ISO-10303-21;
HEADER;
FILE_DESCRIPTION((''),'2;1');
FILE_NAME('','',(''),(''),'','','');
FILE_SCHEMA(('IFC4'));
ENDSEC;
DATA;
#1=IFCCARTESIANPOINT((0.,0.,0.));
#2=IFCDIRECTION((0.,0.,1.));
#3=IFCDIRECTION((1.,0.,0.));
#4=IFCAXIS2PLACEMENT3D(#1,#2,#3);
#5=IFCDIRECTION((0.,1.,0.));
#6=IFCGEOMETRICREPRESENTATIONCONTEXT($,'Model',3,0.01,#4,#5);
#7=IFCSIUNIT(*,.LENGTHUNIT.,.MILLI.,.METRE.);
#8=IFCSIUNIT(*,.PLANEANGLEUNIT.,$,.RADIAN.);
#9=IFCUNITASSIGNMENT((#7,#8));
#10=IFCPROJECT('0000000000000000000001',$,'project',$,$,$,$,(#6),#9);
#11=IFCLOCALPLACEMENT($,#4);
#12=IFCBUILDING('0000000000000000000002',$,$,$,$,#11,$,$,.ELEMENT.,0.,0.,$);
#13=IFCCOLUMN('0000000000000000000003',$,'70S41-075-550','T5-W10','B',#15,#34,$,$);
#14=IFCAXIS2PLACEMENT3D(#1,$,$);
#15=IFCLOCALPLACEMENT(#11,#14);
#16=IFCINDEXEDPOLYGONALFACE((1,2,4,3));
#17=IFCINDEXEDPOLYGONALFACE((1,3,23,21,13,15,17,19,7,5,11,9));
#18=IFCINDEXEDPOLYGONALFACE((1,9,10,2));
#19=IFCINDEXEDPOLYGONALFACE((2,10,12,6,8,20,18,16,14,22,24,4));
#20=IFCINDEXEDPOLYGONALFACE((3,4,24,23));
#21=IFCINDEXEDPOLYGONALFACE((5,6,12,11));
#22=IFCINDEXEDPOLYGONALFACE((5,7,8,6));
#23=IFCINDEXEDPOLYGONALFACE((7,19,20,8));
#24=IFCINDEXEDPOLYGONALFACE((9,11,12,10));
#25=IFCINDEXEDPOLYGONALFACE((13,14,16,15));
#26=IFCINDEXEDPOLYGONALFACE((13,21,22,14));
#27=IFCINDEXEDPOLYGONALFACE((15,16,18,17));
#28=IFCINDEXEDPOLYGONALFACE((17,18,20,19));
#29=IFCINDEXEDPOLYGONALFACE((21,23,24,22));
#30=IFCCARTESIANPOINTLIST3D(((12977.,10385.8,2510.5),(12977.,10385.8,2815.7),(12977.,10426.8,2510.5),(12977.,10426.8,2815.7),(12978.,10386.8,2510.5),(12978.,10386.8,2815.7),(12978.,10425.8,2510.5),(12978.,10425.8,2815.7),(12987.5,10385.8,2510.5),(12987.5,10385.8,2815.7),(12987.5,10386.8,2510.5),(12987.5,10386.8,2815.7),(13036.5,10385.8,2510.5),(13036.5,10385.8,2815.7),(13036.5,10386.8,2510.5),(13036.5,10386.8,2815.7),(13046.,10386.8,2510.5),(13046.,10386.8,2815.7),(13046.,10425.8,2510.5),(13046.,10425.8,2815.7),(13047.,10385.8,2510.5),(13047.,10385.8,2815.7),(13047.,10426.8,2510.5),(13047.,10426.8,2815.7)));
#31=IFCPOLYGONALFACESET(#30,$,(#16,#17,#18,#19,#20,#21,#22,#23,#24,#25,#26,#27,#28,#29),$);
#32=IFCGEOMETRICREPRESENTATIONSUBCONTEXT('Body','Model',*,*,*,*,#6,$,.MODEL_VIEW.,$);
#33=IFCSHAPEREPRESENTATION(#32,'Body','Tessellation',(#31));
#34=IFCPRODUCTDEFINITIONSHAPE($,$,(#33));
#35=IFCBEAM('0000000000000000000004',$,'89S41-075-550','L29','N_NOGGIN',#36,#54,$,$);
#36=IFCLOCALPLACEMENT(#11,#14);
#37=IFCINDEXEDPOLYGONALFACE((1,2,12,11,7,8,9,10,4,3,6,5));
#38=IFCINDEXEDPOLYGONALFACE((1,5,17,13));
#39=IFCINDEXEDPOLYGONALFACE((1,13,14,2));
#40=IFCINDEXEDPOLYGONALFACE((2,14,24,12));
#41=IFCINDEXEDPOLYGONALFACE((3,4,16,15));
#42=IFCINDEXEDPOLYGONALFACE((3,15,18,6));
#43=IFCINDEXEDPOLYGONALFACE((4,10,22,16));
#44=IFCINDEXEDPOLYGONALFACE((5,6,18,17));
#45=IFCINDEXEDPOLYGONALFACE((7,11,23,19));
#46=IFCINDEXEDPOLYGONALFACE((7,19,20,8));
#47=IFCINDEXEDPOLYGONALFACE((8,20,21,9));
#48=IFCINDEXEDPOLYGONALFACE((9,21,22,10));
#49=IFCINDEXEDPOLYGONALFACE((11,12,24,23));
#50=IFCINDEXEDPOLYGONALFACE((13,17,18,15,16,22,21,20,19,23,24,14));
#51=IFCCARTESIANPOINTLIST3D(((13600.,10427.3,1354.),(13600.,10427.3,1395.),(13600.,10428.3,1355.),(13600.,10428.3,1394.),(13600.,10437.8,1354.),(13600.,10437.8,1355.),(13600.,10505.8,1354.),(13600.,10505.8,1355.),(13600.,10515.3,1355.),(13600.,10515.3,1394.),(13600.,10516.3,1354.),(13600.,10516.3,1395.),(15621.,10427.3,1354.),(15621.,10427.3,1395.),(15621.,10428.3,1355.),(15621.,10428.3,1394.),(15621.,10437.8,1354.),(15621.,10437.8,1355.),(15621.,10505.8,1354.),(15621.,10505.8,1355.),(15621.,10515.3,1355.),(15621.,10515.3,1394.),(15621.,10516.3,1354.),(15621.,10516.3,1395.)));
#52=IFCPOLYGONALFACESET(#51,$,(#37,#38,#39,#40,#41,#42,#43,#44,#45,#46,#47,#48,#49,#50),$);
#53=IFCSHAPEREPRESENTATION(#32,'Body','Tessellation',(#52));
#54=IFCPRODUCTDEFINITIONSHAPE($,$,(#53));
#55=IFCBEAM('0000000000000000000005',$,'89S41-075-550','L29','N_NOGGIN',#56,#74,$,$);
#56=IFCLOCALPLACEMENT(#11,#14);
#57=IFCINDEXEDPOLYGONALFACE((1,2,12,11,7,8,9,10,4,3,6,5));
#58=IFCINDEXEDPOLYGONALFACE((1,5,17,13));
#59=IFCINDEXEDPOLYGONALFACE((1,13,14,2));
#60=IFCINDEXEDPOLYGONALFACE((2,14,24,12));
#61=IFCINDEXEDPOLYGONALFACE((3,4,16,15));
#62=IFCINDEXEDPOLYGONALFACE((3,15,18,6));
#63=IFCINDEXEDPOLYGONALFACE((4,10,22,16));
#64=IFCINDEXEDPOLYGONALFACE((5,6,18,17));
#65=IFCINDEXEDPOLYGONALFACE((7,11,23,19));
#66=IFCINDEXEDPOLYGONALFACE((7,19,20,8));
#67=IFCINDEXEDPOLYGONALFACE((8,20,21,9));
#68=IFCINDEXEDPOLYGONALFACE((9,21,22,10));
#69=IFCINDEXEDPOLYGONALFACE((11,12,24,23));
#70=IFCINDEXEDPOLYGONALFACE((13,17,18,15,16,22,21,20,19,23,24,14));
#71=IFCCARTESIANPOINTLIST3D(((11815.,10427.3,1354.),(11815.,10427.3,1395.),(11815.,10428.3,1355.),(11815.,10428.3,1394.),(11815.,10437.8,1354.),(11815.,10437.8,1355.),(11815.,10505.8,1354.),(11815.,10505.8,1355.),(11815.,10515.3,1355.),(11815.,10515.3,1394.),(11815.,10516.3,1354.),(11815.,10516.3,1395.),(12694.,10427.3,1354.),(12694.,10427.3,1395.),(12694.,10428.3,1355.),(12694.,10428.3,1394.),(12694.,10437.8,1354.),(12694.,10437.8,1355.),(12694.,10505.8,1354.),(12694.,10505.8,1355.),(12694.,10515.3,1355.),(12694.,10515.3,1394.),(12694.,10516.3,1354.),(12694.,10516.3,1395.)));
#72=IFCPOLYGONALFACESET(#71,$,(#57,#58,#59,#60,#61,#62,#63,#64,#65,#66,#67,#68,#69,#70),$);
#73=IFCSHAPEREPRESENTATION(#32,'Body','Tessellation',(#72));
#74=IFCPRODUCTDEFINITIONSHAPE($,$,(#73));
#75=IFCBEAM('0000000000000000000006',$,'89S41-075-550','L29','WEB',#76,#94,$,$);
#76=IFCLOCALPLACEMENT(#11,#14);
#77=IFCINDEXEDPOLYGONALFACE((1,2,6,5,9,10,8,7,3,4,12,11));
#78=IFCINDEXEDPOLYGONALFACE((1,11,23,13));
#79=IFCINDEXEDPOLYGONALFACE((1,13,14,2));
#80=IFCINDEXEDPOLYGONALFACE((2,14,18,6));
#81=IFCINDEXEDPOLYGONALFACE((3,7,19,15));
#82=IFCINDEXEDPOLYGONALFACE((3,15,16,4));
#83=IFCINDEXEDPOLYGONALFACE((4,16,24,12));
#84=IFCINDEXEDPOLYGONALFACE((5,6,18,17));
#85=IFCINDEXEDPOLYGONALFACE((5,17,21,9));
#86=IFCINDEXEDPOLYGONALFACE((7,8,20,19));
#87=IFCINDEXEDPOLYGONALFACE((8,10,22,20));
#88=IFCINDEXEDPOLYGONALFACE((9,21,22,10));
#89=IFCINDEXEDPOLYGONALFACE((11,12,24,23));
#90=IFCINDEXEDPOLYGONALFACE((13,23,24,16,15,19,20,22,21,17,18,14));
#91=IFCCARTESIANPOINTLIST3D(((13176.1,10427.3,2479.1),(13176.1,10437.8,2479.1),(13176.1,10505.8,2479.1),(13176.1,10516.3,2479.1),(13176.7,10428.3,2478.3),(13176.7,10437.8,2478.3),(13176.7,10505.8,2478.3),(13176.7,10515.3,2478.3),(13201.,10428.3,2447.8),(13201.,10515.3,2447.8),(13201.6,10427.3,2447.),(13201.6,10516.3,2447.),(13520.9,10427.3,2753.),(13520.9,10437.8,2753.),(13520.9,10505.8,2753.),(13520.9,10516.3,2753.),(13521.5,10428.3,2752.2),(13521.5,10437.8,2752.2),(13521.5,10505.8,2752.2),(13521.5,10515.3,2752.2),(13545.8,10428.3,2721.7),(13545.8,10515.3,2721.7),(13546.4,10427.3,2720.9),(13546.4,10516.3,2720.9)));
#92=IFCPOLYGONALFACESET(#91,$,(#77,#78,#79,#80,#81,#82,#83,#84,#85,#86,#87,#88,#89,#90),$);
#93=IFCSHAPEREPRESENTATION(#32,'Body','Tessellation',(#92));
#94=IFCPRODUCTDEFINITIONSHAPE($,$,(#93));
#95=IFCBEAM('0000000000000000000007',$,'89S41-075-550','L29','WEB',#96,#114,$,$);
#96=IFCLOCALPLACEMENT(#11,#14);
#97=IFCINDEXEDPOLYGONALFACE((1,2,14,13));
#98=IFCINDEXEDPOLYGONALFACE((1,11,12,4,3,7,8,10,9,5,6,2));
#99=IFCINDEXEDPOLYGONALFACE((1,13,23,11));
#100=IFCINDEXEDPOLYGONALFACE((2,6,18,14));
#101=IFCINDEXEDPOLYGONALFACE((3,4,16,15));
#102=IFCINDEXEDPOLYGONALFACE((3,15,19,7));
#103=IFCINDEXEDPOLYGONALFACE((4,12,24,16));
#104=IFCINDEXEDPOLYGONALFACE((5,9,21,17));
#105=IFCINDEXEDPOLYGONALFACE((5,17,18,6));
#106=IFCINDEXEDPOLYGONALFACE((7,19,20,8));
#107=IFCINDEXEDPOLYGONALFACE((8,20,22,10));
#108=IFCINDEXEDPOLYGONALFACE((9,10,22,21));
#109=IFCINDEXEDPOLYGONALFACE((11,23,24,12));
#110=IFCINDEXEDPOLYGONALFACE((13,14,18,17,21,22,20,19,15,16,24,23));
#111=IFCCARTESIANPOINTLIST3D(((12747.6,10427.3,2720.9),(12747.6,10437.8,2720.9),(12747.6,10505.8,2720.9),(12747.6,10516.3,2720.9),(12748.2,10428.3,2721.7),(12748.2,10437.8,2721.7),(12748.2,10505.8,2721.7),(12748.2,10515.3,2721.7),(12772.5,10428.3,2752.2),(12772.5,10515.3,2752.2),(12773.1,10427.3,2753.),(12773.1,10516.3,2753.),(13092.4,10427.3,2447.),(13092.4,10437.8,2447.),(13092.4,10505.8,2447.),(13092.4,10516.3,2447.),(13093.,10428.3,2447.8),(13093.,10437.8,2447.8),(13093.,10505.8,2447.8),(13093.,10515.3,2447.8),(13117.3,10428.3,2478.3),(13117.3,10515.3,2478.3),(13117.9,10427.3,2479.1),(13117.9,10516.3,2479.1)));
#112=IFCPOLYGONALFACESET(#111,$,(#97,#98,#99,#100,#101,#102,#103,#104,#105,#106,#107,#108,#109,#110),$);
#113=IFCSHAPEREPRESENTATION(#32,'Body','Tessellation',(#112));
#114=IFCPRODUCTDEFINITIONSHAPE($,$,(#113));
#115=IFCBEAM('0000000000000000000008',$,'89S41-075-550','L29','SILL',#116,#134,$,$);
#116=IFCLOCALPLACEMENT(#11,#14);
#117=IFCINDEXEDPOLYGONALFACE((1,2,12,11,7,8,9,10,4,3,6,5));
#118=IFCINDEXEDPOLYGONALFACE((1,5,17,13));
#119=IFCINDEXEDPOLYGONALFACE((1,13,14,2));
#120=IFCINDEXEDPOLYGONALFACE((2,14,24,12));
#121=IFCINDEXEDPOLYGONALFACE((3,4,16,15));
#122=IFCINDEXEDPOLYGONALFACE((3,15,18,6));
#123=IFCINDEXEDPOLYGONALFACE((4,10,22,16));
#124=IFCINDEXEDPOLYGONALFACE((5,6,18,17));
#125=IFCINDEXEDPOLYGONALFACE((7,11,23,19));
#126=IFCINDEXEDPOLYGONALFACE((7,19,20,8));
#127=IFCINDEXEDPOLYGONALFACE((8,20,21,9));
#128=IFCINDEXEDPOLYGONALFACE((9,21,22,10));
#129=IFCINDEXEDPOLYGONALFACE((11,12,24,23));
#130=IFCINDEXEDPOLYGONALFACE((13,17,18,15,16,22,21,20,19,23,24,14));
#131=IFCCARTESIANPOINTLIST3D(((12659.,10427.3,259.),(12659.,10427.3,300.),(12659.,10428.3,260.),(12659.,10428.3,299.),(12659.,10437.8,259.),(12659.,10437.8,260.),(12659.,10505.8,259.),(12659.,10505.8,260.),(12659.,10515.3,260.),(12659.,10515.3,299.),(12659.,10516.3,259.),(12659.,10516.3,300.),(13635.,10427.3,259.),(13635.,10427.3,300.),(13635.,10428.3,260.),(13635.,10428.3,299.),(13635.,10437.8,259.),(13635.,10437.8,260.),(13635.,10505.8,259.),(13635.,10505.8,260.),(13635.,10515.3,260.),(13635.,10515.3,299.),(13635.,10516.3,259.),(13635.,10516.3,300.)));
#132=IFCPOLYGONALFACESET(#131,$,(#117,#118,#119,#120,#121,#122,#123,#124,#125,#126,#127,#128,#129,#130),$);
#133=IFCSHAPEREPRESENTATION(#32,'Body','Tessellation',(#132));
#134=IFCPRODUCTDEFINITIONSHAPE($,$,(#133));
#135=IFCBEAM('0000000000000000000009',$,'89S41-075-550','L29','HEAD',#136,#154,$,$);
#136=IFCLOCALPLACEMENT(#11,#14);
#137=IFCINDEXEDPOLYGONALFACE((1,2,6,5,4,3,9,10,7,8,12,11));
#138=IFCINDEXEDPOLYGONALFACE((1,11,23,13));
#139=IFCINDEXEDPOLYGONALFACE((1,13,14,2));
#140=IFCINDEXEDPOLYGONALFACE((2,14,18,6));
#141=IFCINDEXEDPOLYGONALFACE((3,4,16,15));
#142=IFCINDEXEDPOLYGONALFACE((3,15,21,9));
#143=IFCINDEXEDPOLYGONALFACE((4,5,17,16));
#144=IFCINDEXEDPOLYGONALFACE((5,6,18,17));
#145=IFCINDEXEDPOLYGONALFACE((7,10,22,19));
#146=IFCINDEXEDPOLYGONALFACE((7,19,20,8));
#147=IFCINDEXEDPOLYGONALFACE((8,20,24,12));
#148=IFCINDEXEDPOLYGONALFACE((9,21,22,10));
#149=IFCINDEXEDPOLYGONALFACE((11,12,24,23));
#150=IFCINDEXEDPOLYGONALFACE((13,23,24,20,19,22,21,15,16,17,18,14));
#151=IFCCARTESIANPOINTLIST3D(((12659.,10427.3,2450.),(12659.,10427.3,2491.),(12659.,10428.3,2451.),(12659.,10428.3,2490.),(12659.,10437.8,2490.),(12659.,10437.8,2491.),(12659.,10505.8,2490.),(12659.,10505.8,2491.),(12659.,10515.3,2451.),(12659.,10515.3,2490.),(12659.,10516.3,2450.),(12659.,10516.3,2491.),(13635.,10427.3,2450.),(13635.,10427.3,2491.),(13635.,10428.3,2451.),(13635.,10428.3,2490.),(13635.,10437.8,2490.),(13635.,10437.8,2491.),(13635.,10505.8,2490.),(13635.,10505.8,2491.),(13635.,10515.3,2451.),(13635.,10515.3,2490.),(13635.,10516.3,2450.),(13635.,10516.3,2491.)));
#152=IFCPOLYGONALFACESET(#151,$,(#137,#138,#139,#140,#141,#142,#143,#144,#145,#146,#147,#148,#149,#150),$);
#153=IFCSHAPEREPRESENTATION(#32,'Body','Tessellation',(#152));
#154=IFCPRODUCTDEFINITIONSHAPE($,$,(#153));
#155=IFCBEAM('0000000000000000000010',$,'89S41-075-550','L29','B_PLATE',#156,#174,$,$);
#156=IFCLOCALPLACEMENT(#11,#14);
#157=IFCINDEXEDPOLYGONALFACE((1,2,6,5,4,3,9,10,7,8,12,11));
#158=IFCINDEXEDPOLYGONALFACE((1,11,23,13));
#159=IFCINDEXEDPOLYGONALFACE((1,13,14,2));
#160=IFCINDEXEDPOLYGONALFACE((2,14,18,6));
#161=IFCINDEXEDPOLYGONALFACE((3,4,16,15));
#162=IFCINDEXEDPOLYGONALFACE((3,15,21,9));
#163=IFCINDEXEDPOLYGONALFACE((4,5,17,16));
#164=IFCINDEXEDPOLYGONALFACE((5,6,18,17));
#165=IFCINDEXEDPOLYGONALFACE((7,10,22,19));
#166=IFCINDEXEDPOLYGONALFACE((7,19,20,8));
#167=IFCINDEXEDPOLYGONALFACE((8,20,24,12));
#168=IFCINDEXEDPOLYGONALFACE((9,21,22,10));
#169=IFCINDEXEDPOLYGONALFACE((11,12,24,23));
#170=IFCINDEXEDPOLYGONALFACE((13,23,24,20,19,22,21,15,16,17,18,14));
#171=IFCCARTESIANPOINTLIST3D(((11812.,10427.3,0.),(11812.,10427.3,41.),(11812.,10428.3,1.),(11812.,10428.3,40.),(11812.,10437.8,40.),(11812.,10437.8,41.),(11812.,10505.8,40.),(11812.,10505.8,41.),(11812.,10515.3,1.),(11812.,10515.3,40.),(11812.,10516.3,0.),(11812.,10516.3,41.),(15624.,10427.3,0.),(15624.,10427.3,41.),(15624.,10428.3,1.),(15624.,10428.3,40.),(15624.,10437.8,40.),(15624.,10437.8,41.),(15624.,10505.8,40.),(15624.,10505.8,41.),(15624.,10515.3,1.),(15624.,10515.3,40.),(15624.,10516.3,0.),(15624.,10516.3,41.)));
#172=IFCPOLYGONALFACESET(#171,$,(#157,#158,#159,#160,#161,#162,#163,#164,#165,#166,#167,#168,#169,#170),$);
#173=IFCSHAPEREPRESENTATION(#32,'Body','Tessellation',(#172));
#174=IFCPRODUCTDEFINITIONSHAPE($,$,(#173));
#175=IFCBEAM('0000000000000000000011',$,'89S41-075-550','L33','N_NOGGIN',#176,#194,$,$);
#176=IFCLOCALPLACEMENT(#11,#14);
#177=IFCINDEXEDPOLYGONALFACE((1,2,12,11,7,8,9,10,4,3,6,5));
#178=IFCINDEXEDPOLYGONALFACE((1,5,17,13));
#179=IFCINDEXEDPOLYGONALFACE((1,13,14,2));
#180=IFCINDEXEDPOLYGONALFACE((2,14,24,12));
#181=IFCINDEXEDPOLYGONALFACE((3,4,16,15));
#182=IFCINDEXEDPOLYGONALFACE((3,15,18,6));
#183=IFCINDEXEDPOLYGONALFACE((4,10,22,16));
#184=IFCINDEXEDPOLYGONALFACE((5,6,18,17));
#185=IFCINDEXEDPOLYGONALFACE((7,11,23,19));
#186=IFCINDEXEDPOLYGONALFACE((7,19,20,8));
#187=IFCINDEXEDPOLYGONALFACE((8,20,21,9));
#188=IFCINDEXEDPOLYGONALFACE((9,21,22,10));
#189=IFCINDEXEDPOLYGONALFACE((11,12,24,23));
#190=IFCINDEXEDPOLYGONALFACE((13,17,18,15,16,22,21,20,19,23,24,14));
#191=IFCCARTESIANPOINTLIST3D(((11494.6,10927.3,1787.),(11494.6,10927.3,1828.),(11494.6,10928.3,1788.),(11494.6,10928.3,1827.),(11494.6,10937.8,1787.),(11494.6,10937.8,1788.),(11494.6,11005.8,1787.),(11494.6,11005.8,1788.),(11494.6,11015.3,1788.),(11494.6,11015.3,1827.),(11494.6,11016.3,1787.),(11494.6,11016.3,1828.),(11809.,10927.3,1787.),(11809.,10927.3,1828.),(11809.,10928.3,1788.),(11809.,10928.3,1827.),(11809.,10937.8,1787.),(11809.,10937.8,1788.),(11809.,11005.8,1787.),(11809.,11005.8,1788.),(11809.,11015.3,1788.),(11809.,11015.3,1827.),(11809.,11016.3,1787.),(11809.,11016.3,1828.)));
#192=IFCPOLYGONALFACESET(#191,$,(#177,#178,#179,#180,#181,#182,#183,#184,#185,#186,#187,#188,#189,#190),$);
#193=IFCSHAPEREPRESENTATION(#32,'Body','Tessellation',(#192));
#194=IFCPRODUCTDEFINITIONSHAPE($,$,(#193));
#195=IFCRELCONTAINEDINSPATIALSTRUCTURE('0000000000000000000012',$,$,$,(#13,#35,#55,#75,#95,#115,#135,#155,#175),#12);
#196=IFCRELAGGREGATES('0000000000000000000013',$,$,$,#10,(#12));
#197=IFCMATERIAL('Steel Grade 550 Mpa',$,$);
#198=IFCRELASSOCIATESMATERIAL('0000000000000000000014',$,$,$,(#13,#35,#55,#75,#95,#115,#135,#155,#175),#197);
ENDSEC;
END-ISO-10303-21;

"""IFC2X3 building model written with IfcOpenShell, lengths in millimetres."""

from ifc_helpers import new_model, si_unit, direction, frame, origin, origin_with_axes, origin_2d_with_axis, place, context, subcontext, project, spatial, c_section, extrude, source, transform, mapped, material, element, save


model = new_model("IFC2X3")

# Units and contexts
model_context = context("Model", 3, precision=0.01, world=origin_with_axes(), true_north=direction((0.0, 1.0, 0.0)))
body_context = subcontext(model_context, "Body", "Model", "MODEL_VIEW")
ifc_project = project(units=[si_unit("LENGTHUNIT", "METRE", prefix="MILLI"), si_unit("PLANEANGLEUNIT", "RADIAN")], contexts=[model_context])

# Building
building_placement = place(None, origin_with_axes())
building = spatial("IfcBuilding", under=ifc_project, at=building_placement, CompositionType="ELEMENT", ElevationOfRefHeight=0.0, ElevationOfTerrain=0.0)

# Column
ifc_material = material(Name="Steel Grade 550 Mpa")
shared_shape_1 = source(origin(), body_context, "Body", "SweptSolid", [
    extrude(c_section(Depth=70.0, Width=41.0, WallThickness=1.0, Girth=10.5, at=origin_2d_with_axis()), origin_with_axes(), (0.0, 0.0, 1.0), 305.2),
])
column_1_placement = place(None, frame((13012.0, 10406.3, 2510.5), z_axis=(0.0, 0.0, 1.0), x_axis=(0.000004, -1.0, 0.0)))
element("IfcColumn", 1, at=column_1_placement, inside=building, material=ifc_material, Name="70S41-075-550", Description="T5-W10", ObjectType="B", context=body_context, shape_type="MappedRepresentation", body=[
    mapped(shared_shape_1, transform((0.0, 0.0, 0.0), scale=1.0)),
])

# Beams
shared_shape_2 = source(origin(), body_context, "Body", "SweptSolid", [
    extrude(c_section(Depth=89.0, Width=41.0, WallThickness=1.0, Girth=10.5, at=origin_2d_with_axis()), origin_with_axes(), (0.0, 0.0, 1.0), 2021.0),
])
beam_1_placement = place(None, frame((13600.0, 10471.8, 1374.5), z_axis=(1.0, 0.0, 0.0), x_axis=(0.0, 0.0, -1.0)))
element("IfcBeam", 2, at=beam_1_placement, inside=building, material=ifc_material, Name="89S41-075-550", Description="L29", ObjectType="N_NOGGIN", context=body_context, shape_type="MappedRepresentation", body=[
    mapped(shared_shape_2, transform((0.0, 0.0, 0.0), scale=1.0)),
])
shared_shape_3 = source(origin(), body_context, "Body", "SweptSolid", [
    extrude(c_section(Depth=89.0, Width=41.0, WallThickness=1.0, Girth=10.5, at=origin_2d_with_axis()), origin_with_axes(), (0.0, 0.0, 1.0), 879.0),
])
beam_2_placement = place(None, frame((11815.0, 10471.8, 1374.5), z_axis=(1.0, 0.0, 0.0), x_axis=(0.0, 0.0, -1.0)))
element("IfcBeam", 3, at=beam_2_placement, inside=building, material=ifc_material, Name="89S41-075-550", Description="L29", ObjectType="N_NOGGIN", context=body_context, shape_type="MappedRepresentation", body=[
    mapped(shared_shape_3, transform((0.0, 0.0, 0.0), scale=1.0)),
])
shared_shape_4 = source(origin(), body_context, "Body", "SweptSolid", [
    extrude(c_section(Depth=89.0, Width=41.0, WallThickness=1.0, Girth=10.5, at=origin_2d_with_axis()), origin_with_axes(), (0.0, 0.0, 1.0), 440.4),
])
beam_3_placement = place(None, frame((13188.9, 10471.8, 2463.0), z_axis=(0.782968, 0.0, 0.622061), x_axis=(-0.622061, 0.0, 0.782968)))
element("IfcBeam", 4, at=beam_3_placement, inside=building, material=ifc_material, Name="89S41-075-550", Description="L29", ObjectType="WEB", context=body_context, shape_type="MappedRepresentation", body=[
    mapped(shared_shape_4, transform((0.0, 0.0, 0.0), scale=1.0)),
])
shared_shape_5 = source(origin(), body_context, "Body", "SweptSolid", [
    extrude(c_section(Depth=89.0, Width=41.0, WallThickness=1.0, Girth=10.5, at=origin_2d_with_axis()), origin_with_axes(), (0.0, 0.0, 1.0), 440.4),
])
beam_4_placement = place(None, frame((13105.2, 10471.8, 2463.0), z_axis=(-0.782978, 0.0, 0.622049), x_axis=(-0.622049, 0.0, -0.782978)))
element("IfcBeam", 5, at=beam_4_placement, inside=building, material=ifc_material, Name="89S41-075-550", Description="L29", ObjectType="WEB", context=body_context, shape_type="MappedRepresentation", body=[
    mapped(shared_shape_5, transform((0.0, 0.0, 0.0), scale=1.0)),
])
shared_shape_6 = source(origin(), body_context, "Body", "SweptSolid", [
    extrude(c_section(Depth=89.0, Width=41.0, WallThickness=1.0, Girth=10.5, at=origin_2d_with_axis()), origin_with_axes(), (0.0, 0.0, 1.0), 976.0),
])
beam_5_placement = place(None, frame((12659.0, 10471.8, 279.5), z_axis=(1.0, 0.0, 0.0), x_axis=(0.0, 0.0, -1.0)))
element("IfcBeam", 6, at=beam_5_placement, inside=building, material=ifc_material, Name="89S41-075-550", Description="L29", ObjectType="SILL", context=body_context, shape_type="MappedRepresentation", body=[
    mapped(shared_shape_6, transform((0.0, 0.0, 0.0), scale=1.0)),
])
shared_shape_7 = source(origin(), body_context, "Body", "SweptSolid", [
    extrude(c_section(Depth=89.0, Width=41.0, WallThickness=1.0, Girth=10.5, at=origin_2d_with_axis()), origin_with_axes(), (0.0, 0.0, 1.0), 976.0),
])
beam_6_placement = place(None, frame((12659.0, 10471.8, 2470.5), z_axis=(1.0, 0.0, 0.0), x_axis=(0.0, 0.0, 1.0)))
element("IfcBeam", 7, at=beam_6_placement, inside=building, material=ifc_material, Name="89S41-075-550", Description="L29", ObjectType="HEAD", context=body_context, shape_type="MappedRepresentation", body=[
    mapped(shared_shape_7, transform((0.0, 0.0, 0.0), scale=1.0)),
])
shared_shape_8 = source(origin(), body_context, "Body", "SweptSolid", [
    extrude(c_section(Depth=89.0, Width=41.0, WallThickness=1.0, Girth=10.5, at=origin_2d_with_axis()), origin_with_axes(), (0.0, 0.0, 1.0), 3812.0),
])
beam_7_placement = place(None, frame((11812.0, 10471.8, 20.5), z_axis=(1.0, 0.0, 0.0), x_axis=(0.0, 0.0, 1.0)))
element("IfcBeam", 8, at=beam_7_placement, inside=building, material=ifc_material, Name="89S41-075-550", Description="L29", ObjectType="B_PLATE", context=body_context, shape_type="MappedRepresentation", body=[
    mapped(shared_shape_8, transform((0.0, 0.0, 0.0), scale=1.0)),
])
shared_shape_9 = source(origin(), body_context, "Body", "SweptSolid", [
    extrude(c_section(Depth=89.0, Width=41.0, WallThickness=1.0, Girth=10.5, at=origin_2d_with_axis()), origin_with_axes(), (0.0, 0.0, 1.0), 314.4),
])
beam_8_placement = place(None, frame((11494.6, 10971.8, 1807.5), z_axis=(1.0, 0.0, 0.0), x_axis=(0.0, 0.0, -1.0)))
element("IfcBeam", 9, at=beam_8_placement, inside=building, material=ifc_material, Name="89S41-075-550", Description="L33", ObjectType="N_NOGGIN", context=body_context, shape_type="MappedRepresentation", body=[
    mapped(shared_shape_9, transform((0.0, 0.0, 0.0), scale=1.0)),
])

save(model, "model.ifc")
